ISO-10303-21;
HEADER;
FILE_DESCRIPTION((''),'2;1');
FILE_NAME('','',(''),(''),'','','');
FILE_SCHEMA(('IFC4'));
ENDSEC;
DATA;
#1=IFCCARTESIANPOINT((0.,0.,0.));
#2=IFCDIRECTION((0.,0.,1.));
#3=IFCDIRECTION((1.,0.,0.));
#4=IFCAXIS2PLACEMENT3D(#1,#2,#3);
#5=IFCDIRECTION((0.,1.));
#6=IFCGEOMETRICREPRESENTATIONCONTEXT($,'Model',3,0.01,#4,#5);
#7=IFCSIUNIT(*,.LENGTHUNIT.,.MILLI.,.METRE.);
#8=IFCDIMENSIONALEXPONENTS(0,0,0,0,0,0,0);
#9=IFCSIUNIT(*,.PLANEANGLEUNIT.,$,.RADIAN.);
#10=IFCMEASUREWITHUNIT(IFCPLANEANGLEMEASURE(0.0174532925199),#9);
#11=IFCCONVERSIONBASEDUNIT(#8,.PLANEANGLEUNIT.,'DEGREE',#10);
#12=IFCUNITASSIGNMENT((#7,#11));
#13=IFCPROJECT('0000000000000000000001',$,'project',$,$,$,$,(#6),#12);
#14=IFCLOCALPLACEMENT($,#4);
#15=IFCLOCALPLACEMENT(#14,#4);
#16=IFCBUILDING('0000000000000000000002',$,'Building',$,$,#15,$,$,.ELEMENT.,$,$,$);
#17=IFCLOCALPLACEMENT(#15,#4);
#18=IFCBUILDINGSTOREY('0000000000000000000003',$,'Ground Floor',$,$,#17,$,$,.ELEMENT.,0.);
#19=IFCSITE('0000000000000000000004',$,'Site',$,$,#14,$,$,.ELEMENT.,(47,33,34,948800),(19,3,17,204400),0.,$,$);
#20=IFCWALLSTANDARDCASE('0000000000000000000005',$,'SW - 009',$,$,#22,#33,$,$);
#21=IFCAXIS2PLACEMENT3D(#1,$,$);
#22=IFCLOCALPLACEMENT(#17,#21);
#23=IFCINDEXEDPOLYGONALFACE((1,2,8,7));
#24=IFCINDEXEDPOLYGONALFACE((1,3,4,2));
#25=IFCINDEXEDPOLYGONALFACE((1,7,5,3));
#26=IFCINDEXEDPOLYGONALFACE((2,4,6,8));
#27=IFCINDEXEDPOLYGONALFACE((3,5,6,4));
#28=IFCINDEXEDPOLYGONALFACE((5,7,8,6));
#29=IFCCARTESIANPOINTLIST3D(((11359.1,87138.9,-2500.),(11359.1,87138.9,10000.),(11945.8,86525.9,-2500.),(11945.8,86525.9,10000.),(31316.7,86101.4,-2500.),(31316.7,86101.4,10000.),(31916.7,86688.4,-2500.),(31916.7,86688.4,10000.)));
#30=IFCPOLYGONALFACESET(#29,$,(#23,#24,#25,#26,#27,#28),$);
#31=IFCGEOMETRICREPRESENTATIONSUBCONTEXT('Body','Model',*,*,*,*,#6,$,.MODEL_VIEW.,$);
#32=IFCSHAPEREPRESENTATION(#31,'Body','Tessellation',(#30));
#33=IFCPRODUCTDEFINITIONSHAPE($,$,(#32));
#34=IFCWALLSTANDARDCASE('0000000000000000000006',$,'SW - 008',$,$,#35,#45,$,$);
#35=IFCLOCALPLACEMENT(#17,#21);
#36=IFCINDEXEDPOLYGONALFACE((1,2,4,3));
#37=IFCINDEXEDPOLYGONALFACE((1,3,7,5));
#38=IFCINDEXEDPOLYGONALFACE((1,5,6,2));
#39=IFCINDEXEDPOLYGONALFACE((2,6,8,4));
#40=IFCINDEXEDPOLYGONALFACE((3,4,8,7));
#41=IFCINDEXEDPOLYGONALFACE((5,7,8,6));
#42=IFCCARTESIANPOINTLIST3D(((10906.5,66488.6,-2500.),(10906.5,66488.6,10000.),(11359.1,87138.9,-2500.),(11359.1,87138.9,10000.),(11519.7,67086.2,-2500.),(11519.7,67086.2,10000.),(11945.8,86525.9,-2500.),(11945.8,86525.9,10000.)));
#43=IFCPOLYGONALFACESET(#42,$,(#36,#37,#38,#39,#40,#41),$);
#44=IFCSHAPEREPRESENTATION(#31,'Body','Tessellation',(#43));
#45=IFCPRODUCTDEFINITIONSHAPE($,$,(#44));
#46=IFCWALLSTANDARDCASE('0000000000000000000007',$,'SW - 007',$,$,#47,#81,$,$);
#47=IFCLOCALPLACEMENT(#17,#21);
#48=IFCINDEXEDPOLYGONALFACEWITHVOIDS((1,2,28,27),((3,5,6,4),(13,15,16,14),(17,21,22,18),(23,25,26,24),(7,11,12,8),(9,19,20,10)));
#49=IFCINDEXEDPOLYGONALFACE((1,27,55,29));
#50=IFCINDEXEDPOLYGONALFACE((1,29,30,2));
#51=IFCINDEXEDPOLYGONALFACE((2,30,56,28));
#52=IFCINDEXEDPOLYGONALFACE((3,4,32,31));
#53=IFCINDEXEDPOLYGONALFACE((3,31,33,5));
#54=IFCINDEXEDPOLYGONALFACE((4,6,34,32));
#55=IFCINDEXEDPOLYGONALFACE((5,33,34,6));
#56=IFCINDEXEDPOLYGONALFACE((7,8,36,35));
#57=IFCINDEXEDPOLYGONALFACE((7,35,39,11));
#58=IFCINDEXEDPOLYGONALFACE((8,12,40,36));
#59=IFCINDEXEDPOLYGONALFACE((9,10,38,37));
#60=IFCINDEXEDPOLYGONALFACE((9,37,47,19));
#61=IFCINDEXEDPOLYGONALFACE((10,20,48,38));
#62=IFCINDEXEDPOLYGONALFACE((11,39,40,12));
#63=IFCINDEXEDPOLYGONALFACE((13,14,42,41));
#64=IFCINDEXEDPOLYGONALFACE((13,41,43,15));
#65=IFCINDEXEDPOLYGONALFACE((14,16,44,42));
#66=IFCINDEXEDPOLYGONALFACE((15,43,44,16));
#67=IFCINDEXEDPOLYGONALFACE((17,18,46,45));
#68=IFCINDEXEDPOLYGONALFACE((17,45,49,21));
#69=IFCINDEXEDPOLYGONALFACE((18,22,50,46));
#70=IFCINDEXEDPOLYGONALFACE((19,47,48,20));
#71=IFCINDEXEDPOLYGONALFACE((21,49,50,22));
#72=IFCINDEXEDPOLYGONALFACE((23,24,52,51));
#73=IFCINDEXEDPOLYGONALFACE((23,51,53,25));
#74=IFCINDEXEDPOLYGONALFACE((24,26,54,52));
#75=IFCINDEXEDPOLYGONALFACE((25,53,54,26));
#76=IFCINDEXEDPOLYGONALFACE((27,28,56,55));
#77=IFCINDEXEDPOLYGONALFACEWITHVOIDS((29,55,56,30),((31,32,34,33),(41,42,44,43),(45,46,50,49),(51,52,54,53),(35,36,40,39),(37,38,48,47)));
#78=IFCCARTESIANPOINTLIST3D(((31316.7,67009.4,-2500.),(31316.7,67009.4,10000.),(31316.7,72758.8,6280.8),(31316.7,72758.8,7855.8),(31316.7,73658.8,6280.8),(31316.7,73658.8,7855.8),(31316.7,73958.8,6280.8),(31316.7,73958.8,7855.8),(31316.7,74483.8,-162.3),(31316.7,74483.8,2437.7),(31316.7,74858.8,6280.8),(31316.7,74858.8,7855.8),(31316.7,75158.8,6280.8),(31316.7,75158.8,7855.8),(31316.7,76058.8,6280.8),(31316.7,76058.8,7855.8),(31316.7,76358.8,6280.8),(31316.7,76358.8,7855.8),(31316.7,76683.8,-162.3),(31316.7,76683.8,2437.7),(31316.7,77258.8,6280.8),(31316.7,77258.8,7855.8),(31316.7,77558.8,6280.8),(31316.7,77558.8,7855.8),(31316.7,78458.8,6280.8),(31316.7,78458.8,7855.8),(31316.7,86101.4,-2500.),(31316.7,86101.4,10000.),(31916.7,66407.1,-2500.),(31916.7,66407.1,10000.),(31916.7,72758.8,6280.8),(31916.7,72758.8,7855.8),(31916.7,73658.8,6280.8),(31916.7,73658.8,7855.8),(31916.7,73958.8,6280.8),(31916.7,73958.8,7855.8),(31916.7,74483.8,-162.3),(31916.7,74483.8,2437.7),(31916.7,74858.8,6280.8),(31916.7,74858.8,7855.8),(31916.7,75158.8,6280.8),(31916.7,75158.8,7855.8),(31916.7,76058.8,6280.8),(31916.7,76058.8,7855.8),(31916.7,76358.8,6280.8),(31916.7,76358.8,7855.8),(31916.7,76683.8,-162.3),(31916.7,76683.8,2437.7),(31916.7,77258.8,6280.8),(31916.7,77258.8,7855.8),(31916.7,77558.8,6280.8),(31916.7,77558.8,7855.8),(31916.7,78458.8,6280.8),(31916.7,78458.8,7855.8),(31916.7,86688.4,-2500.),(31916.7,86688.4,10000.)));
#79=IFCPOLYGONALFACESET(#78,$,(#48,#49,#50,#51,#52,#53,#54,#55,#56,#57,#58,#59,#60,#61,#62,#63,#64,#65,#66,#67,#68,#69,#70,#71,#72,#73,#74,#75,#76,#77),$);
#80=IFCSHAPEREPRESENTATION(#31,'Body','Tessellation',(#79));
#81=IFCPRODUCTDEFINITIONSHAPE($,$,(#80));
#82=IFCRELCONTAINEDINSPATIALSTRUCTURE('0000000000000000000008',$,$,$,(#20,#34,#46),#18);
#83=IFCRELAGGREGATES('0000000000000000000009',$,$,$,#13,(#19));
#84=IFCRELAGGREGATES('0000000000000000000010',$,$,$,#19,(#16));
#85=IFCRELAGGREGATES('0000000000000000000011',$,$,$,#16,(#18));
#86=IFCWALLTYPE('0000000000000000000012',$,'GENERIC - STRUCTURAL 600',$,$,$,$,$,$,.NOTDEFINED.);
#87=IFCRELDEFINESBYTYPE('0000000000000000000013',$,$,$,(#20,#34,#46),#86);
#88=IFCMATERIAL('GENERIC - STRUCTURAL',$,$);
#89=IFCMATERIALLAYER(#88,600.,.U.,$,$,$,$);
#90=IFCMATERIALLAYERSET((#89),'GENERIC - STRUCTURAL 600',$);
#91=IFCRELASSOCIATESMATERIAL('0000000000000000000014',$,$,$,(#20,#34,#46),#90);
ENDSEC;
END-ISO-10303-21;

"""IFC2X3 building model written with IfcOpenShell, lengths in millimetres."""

from ifc_helpers import new_model, entity, si_unit, converted_unit, direction, frame, origin_with_axes, origin_2d_with_axis, place, context, subcontext, project, spatial, polyline, rectangle, outline, extrude, material, layer, layer_set, layer_usage, type_object, element, save


model = new_model("IFC2X3")

# Units and contexts
model_context = context("Model", 3, precision=0.01, world=origin_with_axes(), true_north=direction((0.0, 1.0)))
body_context = subcontext(model_context, "Body", "Model", "MODEL_VIEW")
ifc_project = project(units=[si_unit("LENGTHUNIT", "METRE", prefix="MILLI"), converted_unit("PLANEANGLEUNIT", "DEGREE", entity("IfcPlaneAngleMeasure", 0.0174532925199), si_unit("PLANEANGLEUNIT", "RADIAN"), dimensions=[0, 0, 0, 0, 0, 0, 0])], contexts=[model_context])

# Site, building, storey
site_placement = place(None, origin_with_axes())
site = spatial("IfcSite", under=ifc_project, at=site_placement, Name="Site", CompositionType="ELEMENT", RefLatitude=(47, 33, 34, 948800), RefLongitude=(19, 3, 17, 204400), RefElevation=0.0)
building_placement = place(site_placement, origin_with_axes())
building = spatial("IfcBuilding", under=site, at=building_placement, Name="Building", CompositionType="ELEMENT")
storey_placement = place(building_placement, origin_with_axes())
storey = spatial("IfcBuildingStorey", under=building, at=storey_placement, Name="Ground Floor", CompositionType="ELEMENT", Elevation=0.0)

# Walls
ifc_material = material(Name="GENERIC - STRUCTURAL")
ifc_layer = layer(ifc_material, 600.0, ventilated="UNKNOWN")
ifc_layer_set = layer_set([ifc_layer], Name="GENERIC - STRUCTURAL 600")
ifc_layer_usage_1 = layer_usage(ifc_layer_set, "AXIS2", "NEGATIVE", 0.0)
wall_type = type_object("IfcWallType", Name="GENERIC - STRUCTURAL 600", PredefinedType="NOTDEFINED")
wall_1_placement = place(storey_placement, frame((11359.1, 87138.9, -2500.0), z_axis=(0.0, 0.0, 1.0), x_axis=(0.99976, -0.021911, 0.0)))
element("IfcWallStandardCase", 1, at=wall_1_placement, inside=storey, type_object=wall_type, material=ifc_layer_usage_1, Name="SW - 009", context=body_context, shape_type="SweptSolid", body=[
    extrude(outline(polyline([(600.0, -600.0), (19975.6, -600.0), (20562.6, 0.0), (0.0, 0.0), (600.0, -600.0)])), origin_with_axes(), (0.0, 0.0, 1.0), 12500.0),
])
ifc_layer_usage_2 = layer_usage(ifc_layer_set, "AXIS2", "NEGATIVE", 0.0)
wall_2_placement = place(storey_placement, frame((10906.5, 66488.6, -2500.0), z_axis=(0.0, 0.0, 1.0), x_axis=(0.021911, 0.99976, 0.0)))
element("IfcWallStandardCase", 2, at=wall_2_placement, inside=storey, type_object=wall_type, material=ifc_layer_usage_2, Name="SW - 008", context=body_context, shape_type="SweptSolid", body=[
    extrude(outline(polyline([(610.9, -600.0), (20055.3, -600.0), (20655.3, 0.0), (0.0, 0.0), (610.9, -600.0)])), origin_with_axes(), (0.0, 0.0, 1.0), 12500.0),
])

# Wall, openings
ifc_layer_usage_3 = layer_usage(ifc_layer_set, "AXIS2", "POSITIVE", 0.0)
wall_3_placement = place(storey_placement, frame((31916.7, 66407.1, -2500.0), z_axis=(0.0, 0.0, 1.0), x_axis=(0.0, 1.0, 0.0)))
wall_3 = element("IfcWallStandardCase", 3, at=wall_3_placement, inside=storey, type_object=wall_type, material=ifc_layer_usage_3, Name="SW - 007", context=body_context, shape_type="SweptSolid", body=[
    extrude(outline(polyline([(0.0, 0.0), (20281.3, 0.0), (19694.3, 600.0), (602.3, 600.0), (0.0, 0.0)])), origin_with_axes(), (0.0, 0.0, 1.0), 12500.0),
])
opening_1_placement = place(wall_3_placement, frame((-66407.1, 31916.7, 2500.0), z_axis=(0.0, 0.0, 1.0), x_axis=(0.0, -1.0, 0.0)))
element("IfcOpeningElement", 4, at=opening_1_placement, cuts=wall_3, ObjectType="Empty Opening", context=body_context, shape_type="SweptSolid", body=[
    extrude(rectangle(XDim=900.0, YDim=1575.0, at=origin_2d_with_axis()), frame((32516.7, 78008.8, 7068.3), z_axis=(1.0, 0.0, 0.0), x_axis=(0.0, 1.0, 0.0)), (0.0, 0.0, -1.0), 1800.0),
])
opening_2_placement = place(wall_3_placement, frame((-66407.1, 31916.7, 2500.0), z_axis=(0.0, 0.0, 1.0), x_axis=(0.0, -1.0, 0.0)))
element("IfcOpeningElement", 5, at=opening_2_placement, cuts=wall_3, ObjectType="Empty Opening", context=body_context, shape_type="SweptSolid", body=[
    extrude(rectangle(XDim=900.0, YDim=1575.0, at=origin_2d_with_axis()), frame((32516.7, 76808.8, 7068.3), z_axis=(1.0, 0.0, 0.0), x_axis=(0.0, 1.0, 0.0)), (0.0, 0.0, -1.0), 1800.0),
])
opening_3_placement = place(wall_3_placement, frame((-66407.1, 31916.7, 2500.0), z_axis=(0.0, 0.0, 1.0), x_axis=(0.0, -1.0, 0.0)))
element("IfcOpeningElement", 6, at=opening_3_placement, cuts=wall_3, ObjectType="Empty Opening", context=body_context, shape_type="SweptSolid", body=[
    extrude(rectangle(XDim=900.0, YDim=1575.0, at=origin_2d_with_axis()), frame((32516.7, 75608.8, 7068.3), z_axis=(1.0, 0.0, 0.0), x_axis=(0.0, 1.0, 0.0)), (0.0, 0.0, -1.0), 1800.0),
])
opening_4_placement = place(wall_3_placement, frame((-66407.1, 31916.7, 2500.0), z_axis=(0.0, 0.0, 1.0), x_axis=(0.0, -1.0, 0.0)))
element("IfcOpeningElement", 7, at=opening_4_placement, cuts=wall_3, ObjectType="Empty Opening", context=body_context, shape_type="SweptSolid", body=[
    extrude(rectangle(XDim=900.0, YDim=1575.0, at=origin_2d_with_axis()), frame((32516.7, 74408.8, 7068.3), z_axis=(1.0, 0.0, 0.0), x_axis=(0.0, 1.0, 0.0)), (0.0, 0.0, -1.0), 1800.0),
])
opening_5_placement = place(wall_3_placement, frame((-66407.1, 31916.7, 2500.0), z_axis=(0.0, 0.0, 1.0), x_axis=(0.0, -1.0, 0.0)))
element("IfcOpeningElement", 8, at=opening_5_placement, cuts=wall_3, ObjectType="Empty Opening", context=body_context, shape_type="SweptSolid", body=[
    extrude(rectangle(XDim=900.0, YDim=1575.0, at=origin_2d_with_axis()), frame((32516.7, 73208.8, 7068.3), z_axis=(1.0, 0.0, 0.0), x_axis=(0.0, 1.0, 0.0)), (0.0, 0.0, -1.0), 1800.0),
])
opening_6_placement = place(wall_3_placement, frame((-66407.1, 31916.7, 2500.0), z_axis=(0.0, 0.0, 1.0), x_axis=(0.0, -1.0, 0.0)))
element("IfcOpeningElement", 9, at=opening_6_placement, cuts=wall_3, ObjectType="Empty Opening", context=body_context, shape_type="SweptSolid", body=[
    extrude(rectangle(XDim=2200.0, YDim=2600.0, at=origin_2d_with_axis()), frame((32516.7, 75583.8, 1137.7), z_axis=(1.0, 0.0, 0.0), x_axis=(0.0, 1.0, 0.0)), (0.0, 0.0, -1.0), 1800.0),
])

save(model, "model.ifc")
